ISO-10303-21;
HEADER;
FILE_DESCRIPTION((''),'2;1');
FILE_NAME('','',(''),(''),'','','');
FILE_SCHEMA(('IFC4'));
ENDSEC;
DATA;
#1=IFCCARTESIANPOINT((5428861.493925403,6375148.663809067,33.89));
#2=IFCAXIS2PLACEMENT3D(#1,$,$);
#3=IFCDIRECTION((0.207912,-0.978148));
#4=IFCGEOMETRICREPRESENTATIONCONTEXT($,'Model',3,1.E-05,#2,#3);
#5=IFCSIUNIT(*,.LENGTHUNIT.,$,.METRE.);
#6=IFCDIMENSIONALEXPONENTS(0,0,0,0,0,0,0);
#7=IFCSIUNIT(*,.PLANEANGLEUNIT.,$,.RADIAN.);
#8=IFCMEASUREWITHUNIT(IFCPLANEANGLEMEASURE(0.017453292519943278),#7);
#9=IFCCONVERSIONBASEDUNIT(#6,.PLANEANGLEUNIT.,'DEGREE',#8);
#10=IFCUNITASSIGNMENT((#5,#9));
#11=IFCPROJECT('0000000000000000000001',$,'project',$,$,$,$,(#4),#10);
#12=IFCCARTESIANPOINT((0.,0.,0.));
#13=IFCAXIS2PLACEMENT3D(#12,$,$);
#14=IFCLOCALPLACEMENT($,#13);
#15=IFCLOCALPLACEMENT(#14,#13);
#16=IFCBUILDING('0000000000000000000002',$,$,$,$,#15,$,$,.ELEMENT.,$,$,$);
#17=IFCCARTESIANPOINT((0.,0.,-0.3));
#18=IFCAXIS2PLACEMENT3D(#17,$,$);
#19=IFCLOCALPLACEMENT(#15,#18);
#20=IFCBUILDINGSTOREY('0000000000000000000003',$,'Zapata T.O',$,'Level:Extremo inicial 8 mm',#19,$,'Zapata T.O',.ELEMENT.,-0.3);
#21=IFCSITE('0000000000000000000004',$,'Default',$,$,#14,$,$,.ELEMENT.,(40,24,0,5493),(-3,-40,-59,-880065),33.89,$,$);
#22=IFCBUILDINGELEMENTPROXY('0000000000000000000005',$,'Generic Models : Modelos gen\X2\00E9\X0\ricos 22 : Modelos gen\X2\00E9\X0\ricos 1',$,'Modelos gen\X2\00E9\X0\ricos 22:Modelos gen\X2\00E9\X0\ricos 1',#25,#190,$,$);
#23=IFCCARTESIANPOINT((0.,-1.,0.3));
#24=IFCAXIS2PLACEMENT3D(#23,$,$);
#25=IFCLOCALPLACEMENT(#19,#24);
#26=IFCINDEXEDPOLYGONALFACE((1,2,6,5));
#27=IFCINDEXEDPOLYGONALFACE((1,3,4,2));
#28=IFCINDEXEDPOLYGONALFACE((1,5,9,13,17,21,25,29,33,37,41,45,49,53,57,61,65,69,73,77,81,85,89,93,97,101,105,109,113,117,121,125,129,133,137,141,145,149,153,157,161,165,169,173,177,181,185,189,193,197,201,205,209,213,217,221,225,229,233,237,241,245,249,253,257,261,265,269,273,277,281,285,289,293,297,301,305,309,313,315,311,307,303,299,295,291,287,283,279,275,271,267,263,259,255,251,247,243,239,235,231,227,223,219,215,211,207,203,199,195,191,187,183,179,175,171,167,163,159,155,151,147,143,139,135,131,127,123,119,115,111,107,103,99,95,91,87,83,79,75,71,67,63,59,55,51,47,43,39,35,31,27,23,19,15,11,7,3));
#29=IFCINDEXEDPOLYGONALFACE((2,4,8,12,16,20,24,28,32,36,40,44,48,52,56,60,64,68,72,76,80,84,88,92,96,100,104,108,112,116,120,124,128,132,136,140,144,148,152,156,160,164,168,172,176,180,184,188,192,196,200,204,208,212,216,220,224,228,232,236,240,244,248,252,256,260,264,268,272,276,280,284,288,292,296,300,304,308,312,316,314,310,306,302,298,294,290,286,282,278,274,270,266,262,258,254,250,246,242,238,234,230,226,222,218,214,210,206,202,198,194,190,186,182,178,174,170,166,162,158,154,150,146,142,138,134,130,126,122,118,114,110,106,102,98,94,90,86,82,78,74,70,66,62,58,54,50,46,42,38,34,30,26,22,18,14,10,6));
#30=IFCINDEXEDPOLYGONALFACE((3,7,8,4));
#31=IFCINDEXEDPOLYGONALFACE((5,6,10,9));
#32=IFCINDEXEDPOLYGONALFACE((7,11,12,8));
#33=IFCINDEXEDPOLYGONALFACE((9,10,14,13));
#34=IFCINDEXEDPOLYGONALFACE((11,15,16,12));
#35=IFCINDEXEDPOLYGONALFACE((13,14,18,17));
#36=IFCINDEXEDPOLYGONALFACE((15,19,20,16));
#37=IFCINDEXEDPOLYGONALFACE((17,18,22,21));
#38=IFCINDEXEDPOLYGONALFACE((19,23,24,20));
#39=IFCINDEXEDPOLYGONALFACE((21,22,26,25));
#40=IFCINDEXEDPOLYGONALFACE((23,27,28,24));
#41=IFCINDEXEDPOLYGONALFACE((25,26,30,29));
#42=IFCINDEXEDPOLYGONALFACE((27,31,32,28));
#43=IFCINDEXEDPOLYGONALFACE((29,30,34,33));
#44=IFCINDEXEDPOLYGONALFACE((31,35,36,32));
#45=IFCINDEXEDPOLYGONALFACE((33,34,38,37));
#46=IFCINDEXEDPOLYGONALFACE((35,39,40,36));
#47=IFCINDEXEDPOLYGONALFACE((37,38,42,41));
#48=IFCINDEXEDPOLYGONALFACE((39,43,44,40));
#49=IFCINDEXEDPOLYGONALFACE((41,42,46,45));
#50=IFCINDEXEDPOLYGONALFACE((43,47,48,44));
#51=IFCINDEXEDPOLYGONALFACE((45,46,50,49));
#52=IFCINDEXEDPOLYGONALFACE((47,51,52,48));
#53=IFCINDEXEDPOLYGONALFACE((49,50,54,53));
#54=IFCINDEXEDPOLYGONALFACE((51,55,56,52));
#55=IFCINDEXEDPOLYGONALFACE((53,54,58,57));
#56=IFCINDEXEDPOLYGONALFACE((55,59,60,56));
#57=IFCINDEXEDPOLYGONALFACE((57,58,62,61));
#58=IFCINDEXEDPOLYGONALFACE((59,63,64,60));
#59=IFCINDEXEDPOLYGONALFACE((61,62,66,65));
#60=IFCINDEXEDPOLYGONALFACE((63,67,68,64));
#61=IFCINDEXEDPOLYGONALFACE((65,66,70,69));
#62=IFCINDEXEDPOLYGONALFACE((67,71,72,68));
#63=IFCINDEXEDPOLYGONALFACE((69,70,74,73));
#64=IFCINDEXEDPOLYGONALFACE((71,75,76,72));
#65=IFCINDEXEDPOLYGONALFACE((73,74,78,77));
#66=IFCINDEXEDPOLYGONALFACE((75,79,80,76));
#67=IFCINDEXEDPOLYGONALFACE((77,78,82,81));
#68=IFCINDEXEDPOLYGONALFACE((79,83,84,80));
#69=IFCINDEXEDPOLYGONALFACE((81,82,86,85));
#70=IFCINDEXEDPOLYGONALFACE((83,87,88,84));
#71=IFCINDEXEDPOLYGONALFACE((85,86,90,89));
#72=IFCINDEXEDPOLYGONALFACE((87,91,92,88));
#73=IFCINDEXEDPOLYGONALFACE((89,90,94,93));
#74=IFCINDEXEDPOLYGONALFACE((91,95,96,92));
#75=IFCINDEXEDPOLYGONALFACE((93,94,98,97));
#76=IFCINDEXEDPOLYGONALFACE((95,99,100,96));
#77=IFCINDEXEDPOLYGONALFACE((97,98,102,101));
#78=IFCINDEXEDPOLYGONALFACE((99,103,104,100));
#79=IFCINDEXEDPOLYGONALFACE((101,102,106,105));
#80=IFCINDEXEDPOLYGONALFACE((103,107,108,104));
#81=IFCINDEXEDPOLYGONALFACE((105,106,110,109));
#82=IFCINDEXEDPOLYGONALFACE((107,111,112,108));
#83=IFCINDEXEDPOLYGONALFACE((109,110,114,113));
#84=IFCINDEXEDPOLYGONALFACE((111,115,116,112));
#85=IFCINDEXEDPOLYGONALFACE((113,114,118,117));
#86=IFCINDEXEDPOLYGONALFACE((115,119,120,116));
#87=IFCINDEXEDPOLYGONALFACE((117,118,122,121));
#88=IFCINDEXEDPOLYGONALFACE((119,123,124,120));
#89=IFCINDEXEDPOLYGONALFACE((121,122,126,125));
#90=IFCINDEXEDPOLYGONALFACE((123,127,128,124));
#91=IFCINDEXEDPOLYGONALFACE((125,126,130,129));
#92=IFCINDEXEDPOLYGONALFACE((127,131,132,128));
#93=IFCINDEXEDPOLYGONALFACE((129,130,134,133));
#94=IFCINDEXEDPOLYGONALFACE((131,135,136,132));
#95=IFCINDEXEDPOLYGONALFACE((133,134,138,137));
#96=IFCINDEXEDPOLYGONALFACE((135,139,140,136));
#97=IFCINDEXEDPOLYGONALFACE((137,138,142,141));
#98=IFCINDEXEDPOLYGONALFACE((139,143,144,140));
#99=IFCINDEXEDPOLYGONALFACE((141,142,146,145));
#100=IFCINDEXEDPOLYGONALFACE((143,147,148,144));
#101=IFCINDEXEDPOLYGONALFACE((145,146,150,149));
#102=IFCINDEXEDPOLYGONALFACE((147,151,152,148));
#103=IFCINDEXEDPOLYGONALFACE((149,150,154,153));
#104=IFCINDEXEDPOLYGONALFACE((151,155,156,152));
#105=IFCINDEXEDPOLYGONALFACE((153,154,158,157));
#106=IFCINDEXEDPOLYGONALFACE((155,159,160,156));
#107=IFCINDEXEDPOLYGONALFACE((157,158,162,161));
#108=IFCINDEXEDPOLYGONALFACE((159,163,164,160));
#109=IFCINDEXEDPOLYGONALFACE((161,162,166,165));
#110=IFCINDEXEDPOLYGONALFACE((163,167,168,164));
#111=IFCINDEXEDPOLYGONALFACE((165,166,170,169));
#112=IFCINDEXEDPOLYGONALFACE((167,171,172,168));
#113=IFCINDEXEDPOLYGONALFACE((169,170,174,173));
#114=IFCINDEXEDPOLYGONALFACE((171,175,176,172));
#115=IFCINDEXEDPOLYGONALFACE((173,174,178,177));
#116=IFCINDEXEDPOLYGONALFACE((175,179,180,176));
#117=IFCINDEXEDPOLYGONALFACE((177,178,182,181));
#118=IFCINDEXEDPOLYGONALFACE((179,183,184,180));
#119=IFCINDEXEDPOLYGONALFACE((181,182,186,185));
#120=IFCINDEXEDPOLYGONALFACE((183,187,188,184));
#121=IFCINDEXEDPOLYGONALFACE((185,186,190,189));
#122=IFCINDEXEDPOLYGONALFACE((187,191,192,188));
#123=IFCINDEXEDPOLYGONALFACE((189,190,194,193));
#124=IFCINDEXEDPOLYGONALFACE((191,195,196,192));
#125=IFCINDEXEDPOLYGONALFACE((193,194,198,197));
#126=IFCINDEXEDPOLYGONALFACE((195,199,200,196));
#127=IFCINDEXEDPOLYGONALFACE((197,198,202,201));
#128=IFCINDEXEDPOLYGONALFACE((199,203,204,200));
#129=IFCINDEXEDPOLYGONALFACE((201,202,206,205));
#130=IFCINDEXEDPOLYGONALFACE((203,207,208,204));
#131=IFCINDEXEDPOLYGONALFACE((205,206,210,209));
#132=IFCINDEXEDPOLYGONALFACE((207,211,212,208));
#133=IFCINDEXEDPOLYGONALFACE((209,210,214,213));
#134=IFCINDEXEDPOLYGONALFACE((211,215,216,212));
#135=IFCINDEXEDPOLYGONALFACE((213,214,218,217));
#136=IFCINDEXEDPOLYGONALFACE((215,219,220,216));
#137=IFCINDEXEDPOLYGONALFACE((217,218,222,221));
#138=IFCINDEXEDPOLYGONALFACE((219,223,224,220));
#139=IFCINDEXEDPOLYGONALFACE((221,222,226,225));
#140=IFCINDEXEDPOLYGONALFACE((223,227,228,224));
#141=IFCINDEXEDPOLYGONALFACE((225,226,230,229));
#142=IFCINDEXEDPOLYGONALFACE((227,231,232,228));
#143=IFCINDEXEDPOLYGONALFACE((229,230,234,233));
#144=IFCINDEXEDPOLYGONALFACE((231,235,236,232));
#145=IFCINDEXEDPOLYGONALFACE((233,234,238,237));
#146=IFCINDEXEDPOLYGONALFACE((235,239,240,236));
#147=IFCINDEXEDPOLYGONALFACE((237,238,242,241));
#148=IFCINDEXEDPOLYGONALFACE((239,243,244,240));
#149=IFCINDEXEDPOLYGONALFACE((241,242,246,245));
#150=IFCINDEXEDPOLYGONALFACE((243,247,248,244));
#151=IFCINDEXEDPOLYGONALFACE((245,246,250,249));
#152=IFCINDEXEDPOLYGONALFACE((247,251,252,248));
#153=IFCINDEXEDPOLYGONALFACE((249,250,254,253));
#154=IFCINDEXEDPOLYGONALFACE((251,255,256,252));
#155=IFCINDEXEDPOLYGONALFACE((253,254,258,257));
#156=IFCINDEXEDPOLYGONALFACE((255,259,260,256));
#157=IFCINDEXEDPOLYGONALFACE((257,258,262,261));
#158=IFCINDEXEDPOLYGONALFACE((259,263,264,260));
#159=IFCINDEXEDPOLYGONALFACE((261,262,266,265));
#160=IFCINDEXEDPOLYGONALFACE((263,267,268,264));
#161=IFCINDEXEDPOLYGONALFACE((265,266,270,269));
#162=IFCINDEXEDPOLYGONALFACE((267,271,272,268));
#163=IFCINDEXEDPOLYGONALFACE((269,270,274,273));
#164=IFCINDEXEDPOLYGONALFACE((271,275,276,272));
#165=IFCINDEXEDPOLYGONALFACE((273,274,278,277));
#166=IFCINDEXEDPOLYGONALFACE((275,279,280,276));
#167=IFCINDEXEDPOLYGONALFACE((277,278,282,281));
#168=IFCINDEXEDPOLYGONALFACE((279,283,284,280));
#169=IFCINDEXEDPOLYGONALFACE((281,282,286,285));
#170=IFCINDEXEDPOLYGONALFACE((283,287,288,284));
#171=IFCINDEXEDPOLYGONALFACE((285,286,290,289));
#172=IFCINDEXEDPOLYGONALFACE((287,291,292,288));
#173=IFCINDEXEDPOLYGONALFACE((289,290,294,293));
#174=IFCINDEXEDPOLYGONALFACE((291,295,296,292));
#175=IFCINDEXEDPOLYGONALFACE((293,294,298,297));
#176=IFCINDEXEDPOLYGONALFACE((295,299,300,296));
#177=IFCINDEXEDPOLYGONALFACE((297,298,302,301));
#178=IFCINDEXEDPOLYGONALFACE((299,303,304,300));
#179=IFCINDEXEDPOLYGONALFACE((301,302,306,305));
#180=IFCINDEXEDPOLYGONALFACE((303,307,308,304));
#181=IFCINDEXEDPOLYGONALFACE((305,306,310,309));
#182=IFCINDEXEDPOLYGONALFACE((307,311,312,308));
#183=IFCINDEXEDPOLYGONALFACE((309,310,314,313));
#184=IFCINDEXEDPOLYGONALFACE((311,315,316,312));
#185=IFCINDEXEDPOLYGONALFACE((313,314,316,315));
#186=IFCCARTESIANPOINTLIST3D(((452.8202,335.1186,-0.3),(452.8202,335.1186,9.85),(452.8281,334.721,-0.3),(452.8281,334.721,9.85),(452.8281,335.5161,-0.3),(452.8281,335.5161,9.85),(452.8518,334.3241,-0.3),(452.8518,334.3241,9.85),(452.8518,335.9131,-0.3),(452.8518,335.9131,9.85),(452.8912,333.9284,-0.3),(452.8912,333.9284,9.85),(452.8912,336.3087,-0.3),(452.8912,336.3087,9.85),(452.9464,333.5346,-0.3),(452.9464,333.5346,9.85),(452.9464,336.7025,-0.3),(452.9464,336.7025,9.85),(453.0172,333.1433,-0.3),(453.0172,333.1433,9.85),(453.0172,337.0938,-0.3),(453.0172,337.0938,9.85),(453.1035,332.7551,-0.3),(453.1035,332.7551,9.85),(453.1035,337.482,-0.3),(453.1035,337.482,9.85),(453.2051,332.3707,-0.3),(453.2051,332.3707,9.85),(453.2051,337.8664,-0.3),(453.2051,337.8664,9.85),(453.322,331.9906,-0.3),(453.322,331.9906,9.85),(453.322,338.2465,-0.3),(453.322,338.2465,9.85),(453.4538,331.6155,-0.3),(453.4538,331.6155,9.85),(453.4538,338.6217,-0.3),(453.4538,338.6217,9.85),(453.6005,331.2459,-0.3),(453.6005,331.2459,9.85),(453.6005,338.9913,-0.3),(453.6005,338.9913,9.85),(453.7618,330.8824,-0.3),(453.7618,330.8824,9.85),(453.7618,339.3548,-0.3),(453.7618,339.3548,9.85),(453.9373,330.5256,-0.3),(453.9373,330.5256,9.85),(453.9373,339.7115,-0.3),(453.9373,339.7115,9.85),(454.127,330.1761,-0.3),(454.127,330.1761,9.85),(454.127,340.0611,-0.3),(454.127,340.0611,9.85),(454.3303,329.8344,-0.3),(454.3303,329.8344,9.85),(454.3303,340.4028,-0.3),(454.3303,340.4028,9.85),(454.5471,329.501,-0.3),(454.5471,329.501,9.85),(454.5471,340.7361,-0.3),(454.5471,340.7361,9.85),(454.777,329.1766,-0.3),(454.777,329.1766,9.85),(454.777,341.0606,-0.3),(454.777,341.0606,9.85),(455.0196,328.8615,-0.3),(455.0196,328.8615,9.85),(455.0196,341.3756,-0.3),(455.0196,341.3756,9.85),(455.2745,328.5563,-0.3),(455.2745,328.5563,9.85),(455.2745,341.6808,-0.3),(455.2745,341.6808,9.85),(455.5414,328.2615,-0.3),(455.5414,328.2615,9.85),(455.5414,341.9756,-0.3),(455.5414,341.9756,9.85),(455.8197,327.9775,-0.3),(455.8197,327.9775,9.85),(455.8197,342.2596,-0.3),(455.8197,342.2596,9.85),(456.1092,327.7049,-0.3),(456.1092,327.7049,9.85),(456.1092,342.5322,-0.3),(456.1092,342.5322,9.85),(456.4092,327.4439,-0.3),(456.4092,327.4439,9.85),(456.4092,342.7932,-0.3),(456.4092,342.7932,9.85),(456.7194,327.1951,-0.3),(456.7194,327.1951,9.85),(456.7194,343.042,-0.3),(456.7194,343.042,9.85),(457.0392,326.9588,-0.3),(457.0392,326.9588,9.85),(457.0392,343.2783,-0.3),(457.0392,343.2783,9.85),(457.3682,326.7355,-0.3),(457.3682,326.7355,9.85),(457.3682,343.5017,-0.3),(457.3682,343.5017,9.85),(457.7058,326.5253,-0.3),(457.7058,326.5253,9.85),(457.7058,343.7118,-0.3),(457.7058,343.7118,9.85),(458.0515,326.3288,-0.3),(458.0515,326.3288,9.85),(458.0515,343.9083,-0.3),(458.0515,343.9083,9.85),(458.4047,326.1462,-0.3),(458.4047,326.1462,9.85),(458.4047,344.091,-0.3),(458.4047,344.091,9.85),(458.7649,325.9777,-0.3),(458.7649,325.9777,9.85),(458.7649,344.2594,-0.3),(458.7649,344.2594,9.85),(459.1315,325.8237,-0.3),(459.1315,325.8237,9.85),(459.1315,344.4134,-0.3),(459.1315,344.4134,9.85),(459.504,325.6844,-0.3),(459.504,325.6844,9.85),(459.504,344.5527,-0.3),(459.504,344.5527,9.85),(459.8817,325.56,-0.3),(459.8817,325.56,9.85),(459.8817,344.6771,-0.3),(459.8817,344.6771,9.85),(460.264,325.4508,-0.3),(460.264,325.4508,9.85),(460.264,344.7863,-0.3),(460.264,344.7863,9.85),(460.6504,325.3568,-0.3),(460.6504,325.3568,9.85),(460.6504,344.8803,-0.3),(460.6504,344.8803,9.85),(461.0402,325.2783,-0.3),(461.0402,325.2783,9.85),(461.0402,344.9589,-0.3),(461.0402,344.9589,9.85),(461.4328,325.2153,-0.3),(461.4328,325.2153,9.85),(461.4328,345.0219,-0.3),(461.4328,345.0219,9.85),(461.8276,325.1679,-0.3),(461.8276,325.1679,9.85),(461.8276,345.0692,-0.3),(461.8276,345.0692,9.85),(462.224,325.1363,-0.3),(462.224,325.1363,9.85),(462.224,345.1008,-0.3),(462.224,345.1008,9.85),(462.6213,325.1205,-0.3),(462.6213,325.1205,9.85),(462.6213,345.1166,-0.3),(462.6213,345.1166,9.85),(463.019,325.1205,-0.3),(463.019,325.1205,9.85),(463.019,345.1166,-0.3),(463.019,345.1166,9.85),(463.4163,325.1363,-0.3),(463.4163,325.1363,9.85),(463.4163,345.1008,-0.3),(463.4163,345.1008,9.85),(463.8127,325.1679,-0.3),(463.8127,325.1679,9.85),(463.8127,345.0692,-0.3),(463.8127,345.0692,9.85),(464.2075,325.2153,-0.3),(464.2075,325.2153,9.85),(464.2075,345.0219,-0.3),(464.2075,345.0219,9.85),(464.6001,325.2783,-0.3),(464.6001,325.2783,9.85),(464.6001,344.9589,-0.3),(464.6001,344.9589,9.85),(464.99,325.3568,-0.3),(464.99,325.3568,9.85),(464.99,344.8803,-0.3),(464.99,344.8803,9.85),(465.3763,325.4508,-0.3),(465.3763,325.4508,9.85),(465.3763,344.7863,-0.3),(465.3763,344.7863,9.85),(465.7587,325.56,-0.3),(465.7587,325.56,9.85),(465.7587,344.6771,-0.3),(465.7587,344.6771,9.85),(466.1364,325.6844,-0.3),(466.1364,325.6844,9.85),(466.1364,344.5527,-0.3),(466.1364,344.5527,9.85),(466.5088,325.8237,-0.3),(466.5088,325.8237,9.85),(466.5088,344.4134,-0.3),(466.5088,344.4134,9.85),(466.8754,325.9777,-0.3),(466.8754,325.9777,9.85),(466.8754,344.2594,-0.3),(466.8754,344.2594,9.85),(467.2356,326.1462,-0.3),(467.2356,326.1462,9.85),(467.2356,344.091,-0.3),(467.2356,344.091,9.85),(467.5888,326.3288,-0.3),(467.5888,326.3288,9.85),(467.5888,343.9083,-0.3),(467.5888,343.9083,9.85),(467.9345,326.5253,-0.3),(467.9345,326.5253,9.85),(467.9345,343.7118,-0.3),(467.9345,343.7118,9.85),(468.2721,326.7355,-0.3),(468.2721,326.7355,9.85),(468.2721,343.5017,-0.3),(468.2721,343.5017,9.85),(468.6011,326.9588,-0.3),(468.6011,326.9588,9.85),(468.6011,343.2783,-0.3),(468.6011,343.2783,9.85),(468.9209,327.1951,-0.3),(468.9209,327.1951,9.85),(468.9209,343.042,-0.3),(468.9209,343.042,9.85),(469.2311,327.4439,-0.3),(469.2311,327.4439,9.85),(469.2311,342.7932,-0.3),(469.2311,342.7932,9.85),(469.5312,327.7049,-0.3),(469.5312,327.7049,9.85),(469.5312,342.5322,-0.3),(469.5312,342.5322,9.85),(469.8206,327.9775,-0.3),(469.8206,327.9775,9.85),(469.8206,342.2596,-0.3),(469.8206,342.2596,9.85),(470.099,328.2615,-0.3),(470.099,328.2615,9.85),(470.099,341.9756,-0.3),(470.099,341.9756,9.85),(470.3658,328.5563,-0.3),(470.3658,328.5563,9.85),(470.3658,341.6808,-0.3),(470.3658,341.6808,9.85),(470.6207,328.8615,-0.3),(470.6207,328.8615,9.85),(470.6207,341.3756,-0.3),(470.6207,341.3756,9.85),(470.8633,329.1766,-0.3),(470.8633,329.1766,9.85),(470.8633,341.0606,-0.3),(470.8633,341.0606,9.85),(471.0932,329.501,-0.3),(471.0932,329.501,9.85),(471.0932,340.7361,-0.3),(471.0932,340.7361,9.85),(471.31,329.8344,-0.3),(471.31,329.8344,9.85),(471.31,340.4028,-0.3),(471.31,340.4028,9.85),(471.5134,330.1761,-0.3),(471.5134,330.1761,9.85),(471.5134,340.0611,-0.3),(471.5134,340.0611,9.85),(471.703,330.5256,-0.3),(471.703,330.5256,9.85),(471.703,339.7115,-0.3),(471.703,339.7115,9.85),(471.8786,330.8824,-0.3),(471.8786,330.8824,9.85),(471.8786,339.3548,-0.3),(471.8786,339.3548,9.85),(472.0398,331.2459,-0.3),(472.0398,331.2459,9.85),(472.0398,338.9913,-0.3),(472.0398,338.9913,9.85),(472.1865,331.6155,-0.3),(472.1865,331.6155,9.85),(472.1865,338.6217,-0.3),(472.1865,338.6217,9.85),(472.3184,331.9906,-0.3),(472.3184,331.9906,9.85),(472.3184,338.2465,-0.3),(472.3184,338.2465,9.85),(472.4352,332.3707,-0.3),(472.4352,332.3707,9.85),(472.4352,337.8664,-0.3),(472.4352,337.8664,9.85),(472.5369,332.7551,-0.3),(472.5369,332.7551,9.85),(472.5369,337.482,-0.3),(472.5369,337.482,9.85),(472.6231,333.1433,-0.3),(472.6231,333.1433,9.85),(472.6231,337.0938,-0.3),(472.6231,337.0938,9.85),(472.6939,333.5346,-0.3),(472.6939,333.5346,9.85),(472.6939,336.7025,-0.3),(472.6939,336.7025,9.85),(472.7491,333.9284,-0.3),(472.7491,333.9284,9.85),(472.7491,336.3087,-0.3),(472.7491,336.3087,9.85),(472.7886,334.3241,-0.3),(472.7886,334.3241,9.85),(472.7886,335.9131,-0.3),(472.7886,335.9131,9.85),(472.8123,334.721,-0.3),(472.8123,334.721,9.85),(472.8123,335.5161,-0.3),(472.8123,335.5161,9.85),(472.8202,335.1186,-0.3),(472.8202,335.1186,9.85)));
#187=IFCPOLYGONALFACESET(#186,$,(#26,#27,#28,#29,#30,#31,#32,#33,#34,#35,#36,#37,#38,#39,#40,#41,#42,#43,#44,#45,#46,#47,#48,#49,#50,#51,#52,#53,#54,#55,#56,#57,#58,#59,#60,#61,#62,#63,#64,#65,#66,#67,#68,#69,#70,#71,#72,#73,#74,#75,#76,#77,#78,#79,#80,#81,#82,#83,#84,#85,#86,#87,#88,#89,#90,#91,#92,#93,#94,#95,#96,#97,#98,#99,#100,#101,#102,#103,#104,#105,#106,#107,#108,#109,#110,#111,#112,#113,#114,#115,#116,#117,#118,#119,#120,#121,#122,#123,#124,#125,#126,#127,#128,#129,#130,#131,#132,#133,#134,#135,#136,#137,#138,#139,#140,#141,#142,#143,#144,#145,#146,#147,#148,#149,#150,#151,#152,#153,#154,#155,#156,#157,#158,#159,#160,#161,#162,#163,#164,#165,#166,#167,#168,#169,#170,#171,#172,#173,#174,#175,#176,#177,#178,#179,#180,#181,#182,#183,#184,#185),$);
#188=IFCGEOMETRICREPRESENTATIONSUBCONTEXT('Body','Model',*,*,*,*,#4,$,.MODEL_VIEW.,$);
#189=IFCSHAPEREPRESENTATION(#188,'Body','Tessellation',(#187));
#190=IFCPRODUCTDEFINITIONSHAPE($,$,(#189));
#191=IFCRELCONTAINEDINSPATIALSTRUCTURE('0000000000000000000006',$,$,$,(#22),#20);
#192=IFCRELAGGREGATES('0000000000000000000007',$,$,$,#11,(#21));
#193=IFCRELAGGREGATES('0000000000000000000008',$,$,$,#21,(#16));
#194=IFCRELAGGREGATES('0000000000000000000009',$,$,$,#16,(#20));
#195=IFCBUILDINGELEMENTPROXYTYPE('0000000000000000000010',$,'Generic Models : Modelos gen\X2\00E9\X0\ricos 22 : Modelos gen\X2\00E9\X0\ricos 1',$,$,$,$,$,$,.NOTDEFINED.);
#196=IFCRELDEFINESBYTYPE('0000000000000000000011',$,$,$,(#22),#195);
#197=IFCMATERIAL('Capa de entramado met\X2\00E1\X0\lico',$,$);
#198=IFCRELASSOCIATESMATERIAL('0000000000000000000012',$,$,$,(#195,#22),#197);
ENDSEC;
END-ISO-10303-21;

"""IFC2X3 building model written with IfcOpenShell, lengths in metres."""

from ifc_helpers import new_model, entity, si_unit, converted_unit, direction, frame, origin, origin_2d_with_axis, place, context, subcontext, project, spatial, circle, extrude, source, transform, mapped, material, type_object, type_shapes, element, save


model = new_model("IFC2X3")

# Units and contexts
model_context = context("Model", 3, precision=1e-05, world=frame((5428861.493925403, 6375148.663809067, 33.89)), true_north=direction((0.207912, -0.978148)))
body_context = subcontext(model_context, "Body", "Model", "MODEL_VIEW")
ifc_project = project(units=[si_unit("LENGTHUNIT", "METRE"), converted_unit("PLANEANGLEUNIT", "DEGREE", entity("IfcPlaneAngleMeasure", 0.017453292519943278), si_unit("PLANEANGLEUNIT", "RADIAN"), dimensions=[0, 0, 0, 0, 0, 0, 0])], contexts=[model_context])

# Site, building, storey
site_placement = place(None, origin())
site = spatial("IfcSite", under=ifc_project, at=site_placement, Name="Default", CompositionType="ELEMENT", RefLatitude=(40, 24, 0, 5493), RefLongitude=(-3, -40, -59, -880065), RefElevation=33.89)
building_placement = place(site_placement, origin())
building = spatial("IfcBuilding", under=site, at=building_placement, CompositionType="ELEMENT")
storey_placement = place(building_placement, frame((0.0, 0.0, -0.3)))
storey = spatial("IfcBuildingStorey", under=building, at=storey_placement, Name="Zapata T.O", ObjectType="Level:Extremo inicial 8 mm", LongName="Zapata T.O", CompositionType="ELEMENT", Elevation=-0.3)

# Building element proxy
ifc_material = material(Name="Capa de entramado metálico")
building_element_proxy_type_1 = type_object("IfcBuildingElementProxyType", Name="Generic Models : Modelos genéricos 22 : Modelos genéricos 1", PredefinedType="NOTDEFINED", material=ifc_material)
shared_shape_1 = source(origin(), body_context, "Body", "SweptSolid", [
    extrude(circle(Radius=10.0, at=origin_2d_with_axis()), frame((462.8202, 335.1186, -0.3)), (0.0, 0.0, 1.0), 10.15),
])
type_shapes(building_element_proxy_type_1, [shared_shape_1])
proxy_1_placement = place(storey_placement, frame((0.0, -1.0, 0.3)))
element("IfcBuildingElementProxy", 1, at=proxy_1_placement, inside=storey, type_object=building_element_proxy_type_1, material=ifc_material, Name="Generic Models : Modelos genéricos 22 : Modelos genéricos 1", ObjectType="Modelos genéricos 22:Modelos genéricos 1", context=body_context, shape_type="MappedRepresentation", body=[
    mapped(shared_shape_1, transform((0.0, 0.0, 0.0), scale=1.0)),
])

save(model, "model.ifc")
